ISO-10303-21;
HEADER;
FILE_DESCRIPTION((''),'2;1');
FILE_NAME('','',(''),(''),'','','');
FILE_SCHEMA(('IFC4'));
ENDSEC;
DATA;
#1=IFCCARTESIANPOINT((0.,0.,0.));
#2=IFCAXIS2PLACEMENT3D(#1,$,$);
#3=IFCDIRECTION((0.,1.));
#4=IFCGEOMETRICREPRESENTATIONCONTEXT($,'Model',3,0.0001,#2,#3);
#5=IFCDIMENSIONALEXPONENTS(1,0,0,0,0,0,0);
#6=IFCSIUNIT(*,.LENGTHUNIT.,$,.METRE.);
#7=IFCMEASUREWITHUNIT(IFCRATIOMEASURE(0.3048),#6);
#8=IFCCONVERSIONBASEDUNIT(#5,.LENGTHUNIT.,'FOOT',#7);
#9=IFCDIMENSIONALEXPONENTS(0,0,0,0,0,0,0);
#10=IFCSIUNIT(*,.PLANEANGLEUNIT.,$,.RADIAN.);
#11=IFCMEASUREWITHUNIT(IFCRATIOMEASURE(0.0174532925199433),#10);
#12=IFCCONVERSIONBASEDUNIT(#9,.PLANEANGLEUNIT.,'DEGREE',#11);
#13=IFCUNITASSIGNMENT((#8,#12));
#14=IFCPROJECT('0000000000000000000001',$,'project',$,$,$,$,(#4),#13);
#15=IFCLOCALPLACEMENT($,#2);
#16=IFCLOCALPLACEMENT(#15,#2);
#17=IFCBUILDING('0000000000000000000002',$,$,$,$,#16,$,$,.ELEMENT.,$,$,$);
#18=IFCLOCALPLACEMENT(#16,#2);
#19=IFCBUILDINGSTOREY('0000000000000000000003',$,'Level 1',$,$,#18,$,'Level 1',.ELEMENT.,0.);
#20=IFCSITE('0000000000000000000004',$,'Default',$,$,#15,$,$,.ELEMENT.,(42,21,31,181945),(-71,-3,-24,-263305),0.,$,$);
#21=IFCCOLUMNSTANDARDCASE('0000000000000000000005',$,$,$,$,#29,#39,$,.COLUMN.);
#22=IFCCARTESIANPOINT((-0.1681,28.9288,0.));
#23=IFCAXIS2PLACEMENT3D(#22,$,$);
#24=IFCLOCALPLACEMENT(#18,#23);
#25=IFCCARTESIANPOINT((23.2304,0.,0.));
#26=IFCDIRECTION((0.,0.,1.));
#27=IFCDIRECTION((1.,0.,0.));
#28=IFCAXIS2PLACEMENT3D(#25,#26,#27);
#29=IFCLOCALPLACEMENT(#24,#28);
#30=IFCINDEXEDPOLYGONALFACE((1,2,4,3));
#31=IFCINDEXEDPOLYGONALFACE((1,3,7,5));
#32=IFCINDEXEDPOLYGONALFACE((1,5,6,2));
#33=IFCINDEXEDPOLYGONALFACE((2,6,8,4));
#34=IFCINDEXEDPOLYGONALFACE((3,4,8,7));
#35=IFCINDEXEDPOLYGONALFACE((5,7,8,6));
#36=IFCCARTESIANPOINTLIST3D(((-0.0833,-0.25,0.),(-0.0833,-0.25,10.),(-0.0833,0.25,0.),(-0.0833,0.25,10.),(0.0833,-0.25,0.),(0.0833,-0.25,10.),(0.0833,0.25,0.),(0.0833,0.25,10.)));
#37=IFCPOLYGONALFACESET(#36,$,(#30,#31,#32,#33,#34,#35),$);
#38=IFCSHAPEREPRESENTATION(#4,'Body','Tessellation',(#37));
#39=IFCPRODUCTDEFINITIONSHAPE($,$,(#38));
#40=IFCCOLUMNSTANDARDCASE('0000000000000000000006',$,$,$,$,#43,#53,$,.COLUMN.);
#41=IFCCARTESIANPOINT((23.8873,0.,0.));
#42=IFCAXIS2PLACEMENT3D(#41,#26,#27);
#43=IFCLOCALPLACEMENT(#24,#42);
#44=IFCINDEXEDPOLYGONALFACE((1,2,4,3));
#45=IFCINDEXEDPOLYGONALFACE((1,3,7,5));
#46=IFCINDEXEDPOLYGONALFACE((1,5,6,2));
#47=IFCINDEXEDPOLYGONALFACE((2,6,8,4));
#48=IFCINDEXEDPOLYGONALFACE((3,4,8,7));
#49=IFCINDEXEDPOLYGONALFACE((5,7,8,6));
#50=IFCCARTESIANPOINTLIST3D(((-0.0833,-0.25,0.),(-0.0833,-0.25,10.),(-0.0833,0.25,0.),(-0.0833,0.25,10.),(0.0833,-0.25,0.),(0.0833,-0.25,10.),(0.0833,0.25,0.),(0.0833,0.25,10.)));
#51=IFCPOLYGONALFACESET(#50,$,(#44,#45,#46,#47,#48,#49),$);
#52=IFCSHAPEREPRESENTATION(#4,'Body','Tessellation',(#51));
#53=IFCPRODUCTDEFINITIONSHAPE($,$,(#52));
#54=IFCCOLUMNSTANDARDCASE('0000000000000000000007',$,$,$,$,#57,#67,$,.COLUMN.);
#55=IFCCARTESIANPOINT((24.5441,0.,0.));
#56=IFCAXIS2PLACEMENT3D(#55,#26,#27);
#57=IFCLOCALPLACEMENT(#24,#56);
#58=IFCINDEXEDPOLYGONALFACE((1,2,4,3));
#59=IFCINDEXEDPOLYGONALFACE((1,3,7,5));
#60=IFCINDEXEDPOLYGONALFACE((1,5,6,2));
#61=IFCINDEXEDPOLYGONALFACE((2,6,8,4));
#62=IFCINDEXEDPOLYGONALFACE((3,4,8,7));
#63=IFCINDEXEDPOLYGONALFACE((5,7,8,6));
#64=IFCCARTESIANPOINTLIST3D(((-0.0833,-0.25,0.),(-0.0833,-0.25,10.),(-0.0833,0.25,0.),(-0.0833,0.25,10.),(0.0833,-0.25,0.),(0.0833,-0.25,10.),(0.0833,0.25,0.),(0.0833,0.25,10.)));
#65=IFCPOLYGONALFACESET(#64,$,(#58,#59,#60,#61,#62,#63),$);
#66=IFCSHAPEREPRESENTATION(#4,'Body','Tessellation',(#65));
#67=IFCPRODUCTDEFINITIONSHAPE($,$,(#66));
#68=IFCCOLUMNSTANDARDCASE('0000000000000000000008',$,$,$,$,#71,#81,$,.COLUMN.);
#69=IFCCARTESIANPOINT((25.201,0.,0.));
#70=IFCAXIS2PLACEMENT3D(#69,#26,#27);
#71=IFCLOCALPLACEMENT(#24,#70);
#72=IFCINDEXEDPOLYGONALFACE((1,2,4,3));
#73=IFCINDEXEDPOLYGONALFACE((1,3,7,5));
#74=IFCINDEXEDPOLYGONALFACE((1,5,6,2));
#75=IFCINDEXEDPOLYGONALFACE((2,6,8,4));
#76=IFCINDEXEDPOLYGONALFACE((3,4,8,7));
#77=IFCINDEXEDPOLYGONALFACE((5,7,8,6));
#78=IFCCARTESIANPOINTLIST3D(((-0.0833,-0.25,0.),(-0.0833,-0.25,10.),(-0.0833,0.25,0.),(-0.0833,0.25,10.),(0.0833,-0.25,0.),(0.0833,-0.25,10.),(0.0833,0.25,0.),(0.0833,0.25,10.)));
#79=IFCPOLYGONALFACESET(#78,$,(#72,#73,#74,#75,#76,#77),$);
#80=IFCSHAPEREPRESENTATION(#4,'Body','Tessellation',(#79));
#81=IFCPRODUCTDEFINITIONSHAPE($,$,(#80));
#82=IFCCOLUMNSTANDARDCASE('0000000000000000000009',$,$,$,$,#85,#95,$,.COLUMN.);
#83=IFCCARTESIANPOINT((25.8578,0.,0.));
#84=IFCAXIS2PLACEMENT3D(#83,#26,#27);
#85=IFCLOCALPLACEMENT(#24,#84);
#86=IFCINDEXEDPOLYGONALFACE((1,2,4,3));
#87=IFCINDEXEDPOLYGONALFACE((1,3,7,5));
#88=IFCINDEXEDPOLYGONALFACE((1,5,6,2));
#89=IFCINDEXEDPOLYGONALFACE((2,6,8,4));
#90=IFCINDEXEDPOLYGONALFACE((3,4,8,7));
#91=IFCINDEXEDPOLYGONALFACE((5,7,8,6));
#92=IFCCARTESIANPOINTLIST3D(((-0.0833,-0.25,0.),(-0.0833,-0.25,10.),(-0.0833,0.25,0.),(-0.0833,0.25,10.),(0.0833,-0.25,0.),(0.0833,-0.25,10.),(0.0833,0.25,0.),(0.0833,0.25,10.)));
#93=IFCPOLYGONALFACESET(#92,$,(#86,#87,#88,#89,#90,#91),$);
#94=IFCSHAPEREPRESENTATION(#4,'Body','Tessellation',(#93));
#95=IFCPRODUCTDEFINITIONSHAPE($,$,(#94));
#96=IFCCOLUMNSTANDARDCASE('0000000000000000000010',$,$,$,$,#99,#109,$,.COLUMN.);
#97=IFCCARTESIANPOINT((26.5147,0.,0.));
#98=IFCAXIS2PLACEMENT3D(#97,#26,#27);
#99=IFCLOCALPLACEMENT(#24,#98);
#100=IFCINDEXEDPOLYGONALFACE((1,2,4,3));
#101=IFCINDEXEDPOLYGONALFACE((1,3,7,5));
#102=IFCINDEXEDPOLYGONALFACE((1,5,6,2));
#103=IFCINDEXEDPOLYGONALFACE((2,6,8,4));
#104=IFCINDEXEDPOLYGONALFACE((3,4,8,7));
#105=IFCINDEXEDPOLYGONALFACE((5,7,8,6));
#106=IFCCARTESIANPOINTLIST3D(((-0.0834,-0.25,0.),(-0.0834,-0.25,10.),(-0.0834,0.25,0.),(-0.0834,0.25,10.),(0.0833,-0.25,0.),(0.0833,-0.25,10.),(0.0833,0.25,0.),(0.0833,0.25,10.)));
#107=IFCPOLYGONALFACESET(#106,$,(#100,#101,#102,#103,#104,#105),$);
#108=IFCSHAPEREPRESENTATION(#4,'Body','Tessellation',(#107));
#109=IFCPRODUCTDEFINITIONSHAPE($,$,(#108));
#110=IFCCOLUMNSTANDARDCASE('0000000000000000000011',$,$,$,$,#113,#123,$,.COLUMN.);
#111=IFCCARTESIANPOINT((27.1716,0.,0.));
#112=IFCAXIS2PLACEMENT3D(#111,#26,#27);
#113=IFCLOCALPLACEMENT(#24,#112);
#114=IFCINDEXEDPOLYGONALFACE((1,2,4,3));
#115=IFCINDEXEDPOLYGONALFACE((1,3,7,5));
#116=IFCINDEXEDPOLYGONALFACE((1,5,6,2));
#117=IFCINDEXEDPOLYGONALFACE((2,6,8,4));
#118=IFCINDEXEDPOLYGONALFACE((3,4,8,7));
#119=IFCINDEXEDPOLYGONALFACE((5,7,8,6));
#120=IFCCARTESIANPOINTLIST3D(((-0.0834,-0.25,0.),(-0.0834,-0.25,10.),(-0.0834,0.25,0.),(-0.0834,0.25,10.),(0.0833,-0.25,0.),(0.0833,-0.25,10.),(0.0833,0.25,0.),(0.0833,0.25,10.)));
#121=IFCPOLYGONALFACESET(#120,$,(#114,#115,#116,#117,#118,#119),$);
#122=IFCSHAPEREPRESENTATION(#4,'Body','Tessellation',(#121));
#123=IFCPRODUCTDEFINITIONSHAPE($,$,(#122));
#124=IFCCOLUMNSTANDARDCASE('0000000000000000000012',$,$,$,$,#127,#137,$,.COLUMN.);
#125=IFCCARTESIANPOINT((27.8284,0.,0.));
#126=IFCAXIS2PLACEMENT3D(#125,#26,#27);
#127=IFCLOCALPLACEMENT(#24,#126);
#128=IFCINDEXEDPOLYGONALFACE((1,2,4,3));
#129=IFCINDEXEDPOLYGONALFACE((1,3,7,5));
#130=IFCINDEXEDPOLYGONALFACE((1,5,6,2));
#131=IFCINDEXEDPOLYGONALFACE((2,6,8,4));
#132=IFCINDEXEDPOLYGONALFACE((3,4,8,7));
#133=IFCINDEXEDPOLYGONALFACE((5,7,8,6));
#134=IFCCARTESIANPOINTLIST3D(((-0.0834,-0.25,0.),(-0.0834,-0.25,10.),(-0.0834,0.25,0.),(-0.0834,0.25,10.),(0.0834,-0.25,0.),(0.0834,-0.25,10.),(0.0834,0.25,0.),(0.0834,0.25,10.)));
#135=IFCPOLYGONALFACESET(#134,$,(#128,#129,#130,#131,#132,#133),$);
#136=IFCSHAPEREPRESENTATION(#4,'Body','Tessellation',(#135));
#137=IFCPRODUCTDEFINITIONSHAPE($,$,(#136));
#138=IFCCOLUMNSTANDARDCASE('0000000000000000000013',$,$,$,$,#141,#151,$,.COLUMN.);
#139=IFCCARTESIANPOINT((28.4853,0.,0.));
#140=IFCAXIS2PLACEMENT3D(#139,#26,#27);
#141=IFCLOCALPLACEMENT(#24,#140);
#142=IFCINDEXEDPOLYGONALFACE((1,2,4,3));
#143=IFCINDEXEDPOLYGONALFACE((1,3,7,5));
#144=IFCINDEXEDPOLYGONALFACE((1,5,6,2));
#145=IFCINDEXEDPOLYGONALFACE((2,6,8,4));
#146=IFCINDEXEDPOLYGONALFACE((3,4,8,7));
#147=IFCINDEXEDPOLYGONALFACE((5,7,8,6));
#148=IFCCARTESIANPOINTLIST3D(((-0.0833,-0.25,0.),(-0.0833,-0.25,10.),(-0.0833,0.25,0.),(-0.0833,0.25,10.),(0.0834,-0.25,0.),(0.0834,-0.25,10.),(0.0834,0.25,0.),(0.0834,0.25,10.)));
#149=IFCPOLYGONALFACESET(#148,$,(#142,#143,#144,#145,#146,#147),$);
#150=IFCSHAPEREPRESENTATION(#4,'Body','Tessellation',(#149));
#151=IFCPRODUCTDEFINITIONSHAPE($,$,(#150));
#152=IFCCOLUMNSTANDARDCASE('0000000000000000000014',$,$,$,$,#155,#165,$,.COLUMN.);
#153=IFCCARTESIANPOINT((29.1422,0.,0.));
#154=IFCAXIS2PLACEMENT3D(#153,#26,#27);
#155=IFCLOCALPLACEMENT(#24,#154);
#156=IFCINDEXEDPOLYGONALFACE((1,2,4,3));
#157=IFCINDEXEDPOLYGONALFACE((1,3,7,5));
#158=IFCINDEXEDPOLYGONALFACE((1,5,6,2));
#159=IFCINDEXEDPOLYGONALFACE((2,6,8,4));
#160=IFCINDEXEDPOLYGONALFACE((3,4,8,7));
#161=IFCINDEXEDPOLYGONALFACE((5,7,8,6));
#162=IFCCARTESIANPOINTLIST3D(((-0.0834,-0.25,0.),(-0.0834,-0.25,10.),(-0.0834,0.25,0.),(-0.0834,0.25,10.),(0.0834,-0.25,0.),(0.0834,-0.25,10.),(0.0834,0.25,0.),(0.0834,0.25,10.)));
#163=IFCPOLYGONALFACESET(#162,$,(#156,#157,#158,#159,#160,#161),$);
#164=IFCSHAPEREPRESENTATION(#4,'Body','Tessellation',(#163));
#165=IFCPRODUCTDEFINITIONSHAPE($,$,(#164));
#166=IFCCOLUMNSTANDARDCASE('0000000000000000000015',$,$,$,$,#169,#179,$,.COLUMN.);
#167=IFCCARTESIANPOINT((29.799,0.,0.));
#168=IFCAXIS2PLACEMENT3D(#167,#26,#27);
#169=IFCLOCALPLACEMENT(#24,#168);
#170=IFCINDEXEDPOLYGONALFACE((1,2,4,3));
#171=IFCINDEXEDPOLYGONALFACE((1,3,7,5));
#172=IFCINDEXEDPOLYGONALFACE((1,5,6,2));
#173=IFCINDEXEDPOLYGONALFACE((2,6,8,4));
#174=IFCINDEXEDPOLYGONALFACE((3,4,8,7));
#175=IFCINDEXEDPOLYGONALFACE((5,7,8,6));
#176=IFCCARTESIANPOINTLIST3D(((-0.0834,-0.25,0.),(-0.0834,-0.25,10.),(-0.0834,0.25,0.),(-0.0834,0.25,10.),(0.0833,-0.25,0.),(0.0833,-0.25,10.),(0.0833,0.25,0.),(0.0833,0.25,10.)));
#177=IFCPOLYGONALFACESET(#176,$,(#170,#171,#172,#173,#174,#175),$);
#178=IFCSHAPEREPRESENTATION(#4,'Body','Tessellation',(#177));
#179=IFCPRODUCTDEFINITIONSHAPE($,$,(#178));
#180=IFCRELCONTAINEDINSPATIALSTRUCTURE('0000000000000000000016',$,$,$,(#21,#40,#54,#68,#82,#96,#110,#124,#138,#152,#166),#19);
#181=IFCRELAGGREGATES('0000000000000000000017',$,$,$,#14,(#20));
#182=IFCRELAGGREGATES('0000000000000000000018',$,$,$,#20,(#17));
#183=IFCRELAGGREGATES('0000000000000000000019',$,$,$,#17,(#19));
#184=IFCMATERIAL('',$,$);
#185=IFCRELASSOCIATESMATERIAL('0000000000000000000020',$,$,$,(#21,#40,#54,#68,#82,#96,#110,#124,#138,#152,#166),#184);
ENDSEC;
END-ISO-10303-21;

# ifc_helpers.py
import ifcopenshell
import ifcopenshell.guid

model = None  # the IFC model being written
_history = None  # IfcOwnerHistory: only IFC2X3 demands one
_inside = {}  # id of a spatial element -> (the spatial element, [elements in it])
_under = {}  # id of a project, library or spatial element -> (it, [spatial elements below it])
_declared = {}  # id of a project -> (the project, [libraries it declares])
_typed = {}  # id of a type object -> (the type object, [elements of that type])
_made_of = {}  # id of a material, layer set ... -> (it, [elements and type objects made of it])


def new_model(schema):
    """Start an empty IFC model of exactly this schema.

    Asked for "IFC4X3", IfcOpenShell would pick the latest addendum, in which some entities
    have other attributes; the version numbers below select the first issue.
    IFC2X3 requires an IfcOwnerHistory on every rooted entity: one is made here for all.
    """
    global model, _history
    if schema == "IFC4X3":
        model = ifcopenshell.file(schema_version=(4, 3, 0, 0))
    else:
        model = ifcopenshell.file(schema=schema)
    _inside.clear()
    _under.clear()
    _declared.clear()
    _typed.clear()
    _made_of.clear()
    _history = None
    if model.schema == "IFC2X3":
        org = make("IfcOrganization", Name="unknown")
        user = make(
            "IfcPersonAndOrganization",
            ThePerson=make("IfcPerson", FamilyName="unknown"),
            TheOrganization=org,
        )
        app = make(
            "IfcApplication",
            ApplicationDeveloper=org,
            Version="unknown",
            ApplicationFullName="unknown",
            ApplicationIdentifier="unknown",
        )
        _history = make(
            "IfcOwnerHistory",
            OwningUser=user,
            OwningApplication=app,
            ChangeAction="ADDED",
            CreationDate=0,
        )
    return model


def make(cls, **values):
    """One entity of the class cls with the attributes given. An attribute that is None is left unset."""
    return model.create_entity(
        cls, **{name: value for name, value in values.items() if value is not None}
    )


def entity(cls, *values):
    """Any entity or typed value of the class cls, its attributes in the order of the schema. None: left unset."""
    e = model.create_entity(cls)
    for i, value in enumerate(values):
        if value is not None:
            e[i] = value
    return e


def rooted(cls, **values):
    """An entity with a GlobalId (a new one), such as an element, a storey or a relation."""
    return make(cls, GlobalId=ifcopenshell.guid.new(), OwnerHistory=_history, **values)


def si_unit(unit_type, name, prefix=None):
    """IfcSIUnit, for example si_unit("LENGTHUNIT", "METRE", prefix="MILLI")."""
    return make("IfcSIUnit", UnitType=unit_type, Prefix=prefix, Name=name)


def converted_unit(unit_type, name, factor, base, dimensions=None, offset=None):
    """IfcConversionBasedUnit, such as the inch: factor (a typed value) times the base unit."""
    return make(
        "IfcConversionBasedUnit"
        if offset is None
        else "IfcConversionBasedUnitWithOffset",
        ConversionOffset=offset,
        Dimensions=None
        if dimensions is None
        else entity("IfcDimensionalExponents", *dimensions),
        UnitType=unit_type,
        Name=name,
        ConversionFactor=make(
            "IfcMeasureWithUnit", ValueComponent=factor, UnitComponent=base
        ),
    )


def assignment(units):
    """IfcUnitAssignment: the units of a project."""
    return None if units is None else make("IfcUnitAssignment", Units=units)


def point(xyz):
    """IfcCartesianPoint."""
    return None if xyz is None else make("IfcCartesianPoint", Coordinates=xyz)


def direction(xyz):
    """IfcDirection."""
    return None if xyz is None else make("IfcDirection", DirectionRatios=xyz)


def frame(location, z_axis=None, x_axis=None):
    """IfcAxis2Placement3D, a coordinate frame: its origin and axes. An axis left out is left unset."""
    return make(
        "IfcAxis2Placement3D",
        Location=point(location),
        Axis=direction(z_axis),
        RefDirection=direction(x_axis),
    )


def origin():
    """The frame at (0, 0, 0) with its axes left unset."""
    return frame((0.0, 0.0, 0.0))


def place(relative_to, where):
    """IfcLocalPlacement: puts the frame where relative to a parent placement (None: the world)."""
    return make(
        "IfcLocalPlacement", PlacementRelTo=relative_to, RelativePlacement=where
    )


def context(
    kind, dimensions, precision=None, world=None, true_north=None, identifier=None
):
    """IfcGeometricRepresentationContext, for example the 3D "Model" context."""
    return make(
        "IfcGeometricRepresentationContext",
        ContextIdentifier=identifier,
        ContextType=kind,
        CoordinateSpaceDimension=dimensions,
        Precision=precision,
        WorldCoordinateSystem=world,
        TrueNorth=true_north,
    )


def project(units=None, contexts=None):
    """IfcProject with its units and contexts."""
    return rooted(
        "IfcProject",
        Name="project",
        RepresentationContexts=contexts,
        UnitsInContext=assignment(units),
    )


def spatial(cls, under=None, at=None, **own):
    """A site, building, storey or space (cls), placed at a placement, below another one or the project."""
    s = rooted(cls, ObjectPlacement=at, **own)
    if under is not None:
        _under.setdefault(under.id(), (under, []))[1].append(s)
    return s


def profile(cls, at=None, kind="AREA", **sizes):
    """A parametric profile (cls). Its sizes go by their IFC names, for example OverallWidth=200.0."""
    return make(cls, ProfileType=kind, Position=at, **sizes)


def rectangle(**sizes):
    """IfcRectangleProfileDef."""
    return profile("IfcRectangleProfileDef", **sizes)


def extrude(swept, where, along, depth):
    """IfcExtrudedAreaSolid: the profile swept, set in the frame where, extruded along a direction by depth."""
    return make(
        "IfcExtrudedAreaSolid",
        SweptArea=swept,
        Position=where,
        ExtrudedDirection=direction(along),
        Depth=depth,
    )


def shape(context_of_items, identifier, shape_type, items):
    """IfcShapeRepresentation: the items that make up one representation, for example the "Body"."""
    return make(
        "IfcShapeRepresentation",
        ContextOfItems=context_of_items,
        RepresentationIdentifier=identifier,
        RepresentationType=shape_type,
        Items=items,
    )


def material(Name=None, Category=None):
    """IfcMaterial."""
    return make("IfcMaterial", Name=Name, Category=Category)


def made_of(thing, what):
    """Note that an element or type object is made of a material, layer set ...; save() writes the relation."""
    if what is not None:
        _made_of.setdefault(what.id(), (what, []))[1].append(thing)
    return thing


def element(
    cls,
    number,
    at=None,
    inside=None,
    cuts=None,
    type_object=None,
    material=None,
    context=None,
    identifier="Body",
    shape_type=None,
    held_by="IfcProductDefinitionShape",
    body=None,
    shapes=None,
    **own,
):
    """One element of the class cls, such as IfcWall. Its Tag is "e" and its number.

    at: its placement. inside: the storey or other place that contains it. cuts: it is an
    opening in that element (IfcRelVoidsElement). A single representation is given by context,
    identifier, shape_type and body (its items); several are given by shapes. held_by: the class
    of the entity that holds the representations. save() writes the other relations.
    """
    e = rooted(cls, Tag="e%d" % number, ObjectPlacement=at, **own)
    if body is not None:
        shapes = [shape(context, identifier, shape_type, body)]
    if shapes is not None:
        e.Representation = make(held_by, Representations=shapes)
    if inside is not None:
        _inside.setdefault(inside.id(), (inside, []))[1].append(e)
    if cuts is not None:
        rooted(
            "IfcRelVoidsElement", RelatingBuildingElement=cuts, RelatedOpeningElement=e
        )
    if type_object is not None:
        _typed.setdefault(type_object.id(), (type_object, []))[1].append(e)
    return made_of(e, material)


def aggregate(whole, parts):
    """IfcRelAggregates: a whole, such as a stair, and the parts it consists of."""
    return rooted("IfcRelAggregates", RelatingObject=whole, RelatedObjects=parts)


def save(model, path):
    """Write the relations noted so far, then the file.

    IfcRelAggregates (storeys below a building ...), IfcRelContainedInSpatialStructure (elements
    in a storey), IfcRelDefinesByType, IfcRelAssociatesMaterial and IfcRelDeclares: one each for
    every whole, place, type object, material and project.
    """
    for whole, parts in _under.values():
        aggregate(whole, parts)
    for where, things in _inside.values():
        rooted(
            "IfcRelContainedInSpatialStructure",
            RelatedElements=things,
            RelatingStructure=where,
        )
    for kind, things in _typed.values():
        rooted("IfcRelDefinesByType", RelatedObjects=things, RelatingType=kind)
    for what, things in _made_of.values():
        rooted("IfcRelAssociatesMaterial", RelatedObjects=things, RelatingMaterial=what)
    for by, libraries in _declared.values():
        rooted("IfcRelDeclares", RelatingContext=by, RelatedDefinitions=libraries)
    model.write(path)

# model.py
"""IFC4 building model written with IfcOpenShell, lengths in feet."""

from ifc_helpers import new_model, entity, si_unit, converted_unit, direction, frame, origin, place, context, project, spatial, rectangle, extrude, material, element, save


model = new_model("IFC4")

# Units and contexts
model_context = context("Model", 3, precision=0.0001, world=origin(), true_north=direction((0.0, 1.0)))
ifc_project = project(units=[converted_unit("LENGTHUNIT", "FOOT", entity("IfcRatioMeasure", 0.3048), si_unit("LENGTHUNIT", "METRE"), dimensions=[1, 0, 0, 0, 0, 0, 0]), converted_unit("PLANEANGLEUNIT", "DEGREE", entity("IfcRatioMeasure", 0.0174532925199433), si_unit("PLANEANGLEUNIT", "RADIAN"), dimensions=[0, 0, 0, 0, 0, 0, 0])], contexts=[model_context])

# Site, building, storey
site_placement = place(None, origin())
site = spatial("IfcSite", under=ifc_project, at=site_placement, Name="Default", CompositionType="ELEMENT", RefLatitude=(42, 21, 31, 181945), RefLongitude=(-71, -3, -24, -263305), RefElevation=0.0)
building_placement = place(site_placement, origin())
building = spatial("IfcBuilding", under=site, at=building_placement, CompositionType="ELEMENT")
storey_placement = place(building_placement, origin())
storey = spatial("IfcBuildingStorey", under=building, at=storey_placement, Name="Level 1", LongName="Level 1", CompositionType="ELEMENT", Elevation=0.0)

# Columns
ifc_material = material(Name="")
placement = place(storey_placement, frame((-0.1681, 28.9288, 0.0)))
for number, where, z_axis, x_axis in (
    (1, (23.2304, 0.0, 0.0), (0.0, 0.0, 1.0), (1.0, 0.0, 0.0)),
    (2, (23.8873, 0.0, 0.0), (0.0, 0.0, 1.0), (1.0, 0.0, 0.0)),
    (3, (24.5441, 0.0, 0.0), (0.0, 0.0, 1.0), (1.0, 0.0, 0.0)),
    (4, (25.201, 0.0, 0.0), (0.0, 0.0, 1.0), (1.0, 0.0, 0.0)),
    (5, (25.8578, 0.0, 0.0), (0.0, 0.0, 1.0), (1.0, 0.0, 0.0)),
    (6, (26.5147, 0.0, 0.0), (0.0, 0.0, 1.0), (1.0, 0.0, 0.0)),
    (7, (27.1716, 0.0, 0.0), (0.0, 0.0, 1.0), (1.0, 0.0, 0.0)),
    (8, (27.8284, 0.0, 0.0), (0.0, 0.0, 1.0), (1.0, 0.0, 0.0)),
    (9, (28.4853, 0.0, 0.0), (0.0, 0.0, 1.0), (1.0, 0.0, 0.0)),
    (10, (29.1422, 0.0, 0.0), (0.0, 0.0, 1.0), (1.0, 0.0, 0.0)),
    (11, (29.799, 0.0, 0.0), (0.0, 0.0, 1.0), (1.0, 0.0, 0.0)),
):
    element("IfcColumnStandardCase", number, at=place(placement, frame(where, z_axis=z_axis, x_axis=x_axis)), inside=storey, material=ifc_material, PredefinedType="COLUMN", context=model_context, shape_type="SweptSolid", body=[
        extrude(rectangle(XDim=0.1667, YDim=0.5), origin(), (0.0, 0.0, 1.0), 10.0),
    ])

save(model, "model.ifc")
